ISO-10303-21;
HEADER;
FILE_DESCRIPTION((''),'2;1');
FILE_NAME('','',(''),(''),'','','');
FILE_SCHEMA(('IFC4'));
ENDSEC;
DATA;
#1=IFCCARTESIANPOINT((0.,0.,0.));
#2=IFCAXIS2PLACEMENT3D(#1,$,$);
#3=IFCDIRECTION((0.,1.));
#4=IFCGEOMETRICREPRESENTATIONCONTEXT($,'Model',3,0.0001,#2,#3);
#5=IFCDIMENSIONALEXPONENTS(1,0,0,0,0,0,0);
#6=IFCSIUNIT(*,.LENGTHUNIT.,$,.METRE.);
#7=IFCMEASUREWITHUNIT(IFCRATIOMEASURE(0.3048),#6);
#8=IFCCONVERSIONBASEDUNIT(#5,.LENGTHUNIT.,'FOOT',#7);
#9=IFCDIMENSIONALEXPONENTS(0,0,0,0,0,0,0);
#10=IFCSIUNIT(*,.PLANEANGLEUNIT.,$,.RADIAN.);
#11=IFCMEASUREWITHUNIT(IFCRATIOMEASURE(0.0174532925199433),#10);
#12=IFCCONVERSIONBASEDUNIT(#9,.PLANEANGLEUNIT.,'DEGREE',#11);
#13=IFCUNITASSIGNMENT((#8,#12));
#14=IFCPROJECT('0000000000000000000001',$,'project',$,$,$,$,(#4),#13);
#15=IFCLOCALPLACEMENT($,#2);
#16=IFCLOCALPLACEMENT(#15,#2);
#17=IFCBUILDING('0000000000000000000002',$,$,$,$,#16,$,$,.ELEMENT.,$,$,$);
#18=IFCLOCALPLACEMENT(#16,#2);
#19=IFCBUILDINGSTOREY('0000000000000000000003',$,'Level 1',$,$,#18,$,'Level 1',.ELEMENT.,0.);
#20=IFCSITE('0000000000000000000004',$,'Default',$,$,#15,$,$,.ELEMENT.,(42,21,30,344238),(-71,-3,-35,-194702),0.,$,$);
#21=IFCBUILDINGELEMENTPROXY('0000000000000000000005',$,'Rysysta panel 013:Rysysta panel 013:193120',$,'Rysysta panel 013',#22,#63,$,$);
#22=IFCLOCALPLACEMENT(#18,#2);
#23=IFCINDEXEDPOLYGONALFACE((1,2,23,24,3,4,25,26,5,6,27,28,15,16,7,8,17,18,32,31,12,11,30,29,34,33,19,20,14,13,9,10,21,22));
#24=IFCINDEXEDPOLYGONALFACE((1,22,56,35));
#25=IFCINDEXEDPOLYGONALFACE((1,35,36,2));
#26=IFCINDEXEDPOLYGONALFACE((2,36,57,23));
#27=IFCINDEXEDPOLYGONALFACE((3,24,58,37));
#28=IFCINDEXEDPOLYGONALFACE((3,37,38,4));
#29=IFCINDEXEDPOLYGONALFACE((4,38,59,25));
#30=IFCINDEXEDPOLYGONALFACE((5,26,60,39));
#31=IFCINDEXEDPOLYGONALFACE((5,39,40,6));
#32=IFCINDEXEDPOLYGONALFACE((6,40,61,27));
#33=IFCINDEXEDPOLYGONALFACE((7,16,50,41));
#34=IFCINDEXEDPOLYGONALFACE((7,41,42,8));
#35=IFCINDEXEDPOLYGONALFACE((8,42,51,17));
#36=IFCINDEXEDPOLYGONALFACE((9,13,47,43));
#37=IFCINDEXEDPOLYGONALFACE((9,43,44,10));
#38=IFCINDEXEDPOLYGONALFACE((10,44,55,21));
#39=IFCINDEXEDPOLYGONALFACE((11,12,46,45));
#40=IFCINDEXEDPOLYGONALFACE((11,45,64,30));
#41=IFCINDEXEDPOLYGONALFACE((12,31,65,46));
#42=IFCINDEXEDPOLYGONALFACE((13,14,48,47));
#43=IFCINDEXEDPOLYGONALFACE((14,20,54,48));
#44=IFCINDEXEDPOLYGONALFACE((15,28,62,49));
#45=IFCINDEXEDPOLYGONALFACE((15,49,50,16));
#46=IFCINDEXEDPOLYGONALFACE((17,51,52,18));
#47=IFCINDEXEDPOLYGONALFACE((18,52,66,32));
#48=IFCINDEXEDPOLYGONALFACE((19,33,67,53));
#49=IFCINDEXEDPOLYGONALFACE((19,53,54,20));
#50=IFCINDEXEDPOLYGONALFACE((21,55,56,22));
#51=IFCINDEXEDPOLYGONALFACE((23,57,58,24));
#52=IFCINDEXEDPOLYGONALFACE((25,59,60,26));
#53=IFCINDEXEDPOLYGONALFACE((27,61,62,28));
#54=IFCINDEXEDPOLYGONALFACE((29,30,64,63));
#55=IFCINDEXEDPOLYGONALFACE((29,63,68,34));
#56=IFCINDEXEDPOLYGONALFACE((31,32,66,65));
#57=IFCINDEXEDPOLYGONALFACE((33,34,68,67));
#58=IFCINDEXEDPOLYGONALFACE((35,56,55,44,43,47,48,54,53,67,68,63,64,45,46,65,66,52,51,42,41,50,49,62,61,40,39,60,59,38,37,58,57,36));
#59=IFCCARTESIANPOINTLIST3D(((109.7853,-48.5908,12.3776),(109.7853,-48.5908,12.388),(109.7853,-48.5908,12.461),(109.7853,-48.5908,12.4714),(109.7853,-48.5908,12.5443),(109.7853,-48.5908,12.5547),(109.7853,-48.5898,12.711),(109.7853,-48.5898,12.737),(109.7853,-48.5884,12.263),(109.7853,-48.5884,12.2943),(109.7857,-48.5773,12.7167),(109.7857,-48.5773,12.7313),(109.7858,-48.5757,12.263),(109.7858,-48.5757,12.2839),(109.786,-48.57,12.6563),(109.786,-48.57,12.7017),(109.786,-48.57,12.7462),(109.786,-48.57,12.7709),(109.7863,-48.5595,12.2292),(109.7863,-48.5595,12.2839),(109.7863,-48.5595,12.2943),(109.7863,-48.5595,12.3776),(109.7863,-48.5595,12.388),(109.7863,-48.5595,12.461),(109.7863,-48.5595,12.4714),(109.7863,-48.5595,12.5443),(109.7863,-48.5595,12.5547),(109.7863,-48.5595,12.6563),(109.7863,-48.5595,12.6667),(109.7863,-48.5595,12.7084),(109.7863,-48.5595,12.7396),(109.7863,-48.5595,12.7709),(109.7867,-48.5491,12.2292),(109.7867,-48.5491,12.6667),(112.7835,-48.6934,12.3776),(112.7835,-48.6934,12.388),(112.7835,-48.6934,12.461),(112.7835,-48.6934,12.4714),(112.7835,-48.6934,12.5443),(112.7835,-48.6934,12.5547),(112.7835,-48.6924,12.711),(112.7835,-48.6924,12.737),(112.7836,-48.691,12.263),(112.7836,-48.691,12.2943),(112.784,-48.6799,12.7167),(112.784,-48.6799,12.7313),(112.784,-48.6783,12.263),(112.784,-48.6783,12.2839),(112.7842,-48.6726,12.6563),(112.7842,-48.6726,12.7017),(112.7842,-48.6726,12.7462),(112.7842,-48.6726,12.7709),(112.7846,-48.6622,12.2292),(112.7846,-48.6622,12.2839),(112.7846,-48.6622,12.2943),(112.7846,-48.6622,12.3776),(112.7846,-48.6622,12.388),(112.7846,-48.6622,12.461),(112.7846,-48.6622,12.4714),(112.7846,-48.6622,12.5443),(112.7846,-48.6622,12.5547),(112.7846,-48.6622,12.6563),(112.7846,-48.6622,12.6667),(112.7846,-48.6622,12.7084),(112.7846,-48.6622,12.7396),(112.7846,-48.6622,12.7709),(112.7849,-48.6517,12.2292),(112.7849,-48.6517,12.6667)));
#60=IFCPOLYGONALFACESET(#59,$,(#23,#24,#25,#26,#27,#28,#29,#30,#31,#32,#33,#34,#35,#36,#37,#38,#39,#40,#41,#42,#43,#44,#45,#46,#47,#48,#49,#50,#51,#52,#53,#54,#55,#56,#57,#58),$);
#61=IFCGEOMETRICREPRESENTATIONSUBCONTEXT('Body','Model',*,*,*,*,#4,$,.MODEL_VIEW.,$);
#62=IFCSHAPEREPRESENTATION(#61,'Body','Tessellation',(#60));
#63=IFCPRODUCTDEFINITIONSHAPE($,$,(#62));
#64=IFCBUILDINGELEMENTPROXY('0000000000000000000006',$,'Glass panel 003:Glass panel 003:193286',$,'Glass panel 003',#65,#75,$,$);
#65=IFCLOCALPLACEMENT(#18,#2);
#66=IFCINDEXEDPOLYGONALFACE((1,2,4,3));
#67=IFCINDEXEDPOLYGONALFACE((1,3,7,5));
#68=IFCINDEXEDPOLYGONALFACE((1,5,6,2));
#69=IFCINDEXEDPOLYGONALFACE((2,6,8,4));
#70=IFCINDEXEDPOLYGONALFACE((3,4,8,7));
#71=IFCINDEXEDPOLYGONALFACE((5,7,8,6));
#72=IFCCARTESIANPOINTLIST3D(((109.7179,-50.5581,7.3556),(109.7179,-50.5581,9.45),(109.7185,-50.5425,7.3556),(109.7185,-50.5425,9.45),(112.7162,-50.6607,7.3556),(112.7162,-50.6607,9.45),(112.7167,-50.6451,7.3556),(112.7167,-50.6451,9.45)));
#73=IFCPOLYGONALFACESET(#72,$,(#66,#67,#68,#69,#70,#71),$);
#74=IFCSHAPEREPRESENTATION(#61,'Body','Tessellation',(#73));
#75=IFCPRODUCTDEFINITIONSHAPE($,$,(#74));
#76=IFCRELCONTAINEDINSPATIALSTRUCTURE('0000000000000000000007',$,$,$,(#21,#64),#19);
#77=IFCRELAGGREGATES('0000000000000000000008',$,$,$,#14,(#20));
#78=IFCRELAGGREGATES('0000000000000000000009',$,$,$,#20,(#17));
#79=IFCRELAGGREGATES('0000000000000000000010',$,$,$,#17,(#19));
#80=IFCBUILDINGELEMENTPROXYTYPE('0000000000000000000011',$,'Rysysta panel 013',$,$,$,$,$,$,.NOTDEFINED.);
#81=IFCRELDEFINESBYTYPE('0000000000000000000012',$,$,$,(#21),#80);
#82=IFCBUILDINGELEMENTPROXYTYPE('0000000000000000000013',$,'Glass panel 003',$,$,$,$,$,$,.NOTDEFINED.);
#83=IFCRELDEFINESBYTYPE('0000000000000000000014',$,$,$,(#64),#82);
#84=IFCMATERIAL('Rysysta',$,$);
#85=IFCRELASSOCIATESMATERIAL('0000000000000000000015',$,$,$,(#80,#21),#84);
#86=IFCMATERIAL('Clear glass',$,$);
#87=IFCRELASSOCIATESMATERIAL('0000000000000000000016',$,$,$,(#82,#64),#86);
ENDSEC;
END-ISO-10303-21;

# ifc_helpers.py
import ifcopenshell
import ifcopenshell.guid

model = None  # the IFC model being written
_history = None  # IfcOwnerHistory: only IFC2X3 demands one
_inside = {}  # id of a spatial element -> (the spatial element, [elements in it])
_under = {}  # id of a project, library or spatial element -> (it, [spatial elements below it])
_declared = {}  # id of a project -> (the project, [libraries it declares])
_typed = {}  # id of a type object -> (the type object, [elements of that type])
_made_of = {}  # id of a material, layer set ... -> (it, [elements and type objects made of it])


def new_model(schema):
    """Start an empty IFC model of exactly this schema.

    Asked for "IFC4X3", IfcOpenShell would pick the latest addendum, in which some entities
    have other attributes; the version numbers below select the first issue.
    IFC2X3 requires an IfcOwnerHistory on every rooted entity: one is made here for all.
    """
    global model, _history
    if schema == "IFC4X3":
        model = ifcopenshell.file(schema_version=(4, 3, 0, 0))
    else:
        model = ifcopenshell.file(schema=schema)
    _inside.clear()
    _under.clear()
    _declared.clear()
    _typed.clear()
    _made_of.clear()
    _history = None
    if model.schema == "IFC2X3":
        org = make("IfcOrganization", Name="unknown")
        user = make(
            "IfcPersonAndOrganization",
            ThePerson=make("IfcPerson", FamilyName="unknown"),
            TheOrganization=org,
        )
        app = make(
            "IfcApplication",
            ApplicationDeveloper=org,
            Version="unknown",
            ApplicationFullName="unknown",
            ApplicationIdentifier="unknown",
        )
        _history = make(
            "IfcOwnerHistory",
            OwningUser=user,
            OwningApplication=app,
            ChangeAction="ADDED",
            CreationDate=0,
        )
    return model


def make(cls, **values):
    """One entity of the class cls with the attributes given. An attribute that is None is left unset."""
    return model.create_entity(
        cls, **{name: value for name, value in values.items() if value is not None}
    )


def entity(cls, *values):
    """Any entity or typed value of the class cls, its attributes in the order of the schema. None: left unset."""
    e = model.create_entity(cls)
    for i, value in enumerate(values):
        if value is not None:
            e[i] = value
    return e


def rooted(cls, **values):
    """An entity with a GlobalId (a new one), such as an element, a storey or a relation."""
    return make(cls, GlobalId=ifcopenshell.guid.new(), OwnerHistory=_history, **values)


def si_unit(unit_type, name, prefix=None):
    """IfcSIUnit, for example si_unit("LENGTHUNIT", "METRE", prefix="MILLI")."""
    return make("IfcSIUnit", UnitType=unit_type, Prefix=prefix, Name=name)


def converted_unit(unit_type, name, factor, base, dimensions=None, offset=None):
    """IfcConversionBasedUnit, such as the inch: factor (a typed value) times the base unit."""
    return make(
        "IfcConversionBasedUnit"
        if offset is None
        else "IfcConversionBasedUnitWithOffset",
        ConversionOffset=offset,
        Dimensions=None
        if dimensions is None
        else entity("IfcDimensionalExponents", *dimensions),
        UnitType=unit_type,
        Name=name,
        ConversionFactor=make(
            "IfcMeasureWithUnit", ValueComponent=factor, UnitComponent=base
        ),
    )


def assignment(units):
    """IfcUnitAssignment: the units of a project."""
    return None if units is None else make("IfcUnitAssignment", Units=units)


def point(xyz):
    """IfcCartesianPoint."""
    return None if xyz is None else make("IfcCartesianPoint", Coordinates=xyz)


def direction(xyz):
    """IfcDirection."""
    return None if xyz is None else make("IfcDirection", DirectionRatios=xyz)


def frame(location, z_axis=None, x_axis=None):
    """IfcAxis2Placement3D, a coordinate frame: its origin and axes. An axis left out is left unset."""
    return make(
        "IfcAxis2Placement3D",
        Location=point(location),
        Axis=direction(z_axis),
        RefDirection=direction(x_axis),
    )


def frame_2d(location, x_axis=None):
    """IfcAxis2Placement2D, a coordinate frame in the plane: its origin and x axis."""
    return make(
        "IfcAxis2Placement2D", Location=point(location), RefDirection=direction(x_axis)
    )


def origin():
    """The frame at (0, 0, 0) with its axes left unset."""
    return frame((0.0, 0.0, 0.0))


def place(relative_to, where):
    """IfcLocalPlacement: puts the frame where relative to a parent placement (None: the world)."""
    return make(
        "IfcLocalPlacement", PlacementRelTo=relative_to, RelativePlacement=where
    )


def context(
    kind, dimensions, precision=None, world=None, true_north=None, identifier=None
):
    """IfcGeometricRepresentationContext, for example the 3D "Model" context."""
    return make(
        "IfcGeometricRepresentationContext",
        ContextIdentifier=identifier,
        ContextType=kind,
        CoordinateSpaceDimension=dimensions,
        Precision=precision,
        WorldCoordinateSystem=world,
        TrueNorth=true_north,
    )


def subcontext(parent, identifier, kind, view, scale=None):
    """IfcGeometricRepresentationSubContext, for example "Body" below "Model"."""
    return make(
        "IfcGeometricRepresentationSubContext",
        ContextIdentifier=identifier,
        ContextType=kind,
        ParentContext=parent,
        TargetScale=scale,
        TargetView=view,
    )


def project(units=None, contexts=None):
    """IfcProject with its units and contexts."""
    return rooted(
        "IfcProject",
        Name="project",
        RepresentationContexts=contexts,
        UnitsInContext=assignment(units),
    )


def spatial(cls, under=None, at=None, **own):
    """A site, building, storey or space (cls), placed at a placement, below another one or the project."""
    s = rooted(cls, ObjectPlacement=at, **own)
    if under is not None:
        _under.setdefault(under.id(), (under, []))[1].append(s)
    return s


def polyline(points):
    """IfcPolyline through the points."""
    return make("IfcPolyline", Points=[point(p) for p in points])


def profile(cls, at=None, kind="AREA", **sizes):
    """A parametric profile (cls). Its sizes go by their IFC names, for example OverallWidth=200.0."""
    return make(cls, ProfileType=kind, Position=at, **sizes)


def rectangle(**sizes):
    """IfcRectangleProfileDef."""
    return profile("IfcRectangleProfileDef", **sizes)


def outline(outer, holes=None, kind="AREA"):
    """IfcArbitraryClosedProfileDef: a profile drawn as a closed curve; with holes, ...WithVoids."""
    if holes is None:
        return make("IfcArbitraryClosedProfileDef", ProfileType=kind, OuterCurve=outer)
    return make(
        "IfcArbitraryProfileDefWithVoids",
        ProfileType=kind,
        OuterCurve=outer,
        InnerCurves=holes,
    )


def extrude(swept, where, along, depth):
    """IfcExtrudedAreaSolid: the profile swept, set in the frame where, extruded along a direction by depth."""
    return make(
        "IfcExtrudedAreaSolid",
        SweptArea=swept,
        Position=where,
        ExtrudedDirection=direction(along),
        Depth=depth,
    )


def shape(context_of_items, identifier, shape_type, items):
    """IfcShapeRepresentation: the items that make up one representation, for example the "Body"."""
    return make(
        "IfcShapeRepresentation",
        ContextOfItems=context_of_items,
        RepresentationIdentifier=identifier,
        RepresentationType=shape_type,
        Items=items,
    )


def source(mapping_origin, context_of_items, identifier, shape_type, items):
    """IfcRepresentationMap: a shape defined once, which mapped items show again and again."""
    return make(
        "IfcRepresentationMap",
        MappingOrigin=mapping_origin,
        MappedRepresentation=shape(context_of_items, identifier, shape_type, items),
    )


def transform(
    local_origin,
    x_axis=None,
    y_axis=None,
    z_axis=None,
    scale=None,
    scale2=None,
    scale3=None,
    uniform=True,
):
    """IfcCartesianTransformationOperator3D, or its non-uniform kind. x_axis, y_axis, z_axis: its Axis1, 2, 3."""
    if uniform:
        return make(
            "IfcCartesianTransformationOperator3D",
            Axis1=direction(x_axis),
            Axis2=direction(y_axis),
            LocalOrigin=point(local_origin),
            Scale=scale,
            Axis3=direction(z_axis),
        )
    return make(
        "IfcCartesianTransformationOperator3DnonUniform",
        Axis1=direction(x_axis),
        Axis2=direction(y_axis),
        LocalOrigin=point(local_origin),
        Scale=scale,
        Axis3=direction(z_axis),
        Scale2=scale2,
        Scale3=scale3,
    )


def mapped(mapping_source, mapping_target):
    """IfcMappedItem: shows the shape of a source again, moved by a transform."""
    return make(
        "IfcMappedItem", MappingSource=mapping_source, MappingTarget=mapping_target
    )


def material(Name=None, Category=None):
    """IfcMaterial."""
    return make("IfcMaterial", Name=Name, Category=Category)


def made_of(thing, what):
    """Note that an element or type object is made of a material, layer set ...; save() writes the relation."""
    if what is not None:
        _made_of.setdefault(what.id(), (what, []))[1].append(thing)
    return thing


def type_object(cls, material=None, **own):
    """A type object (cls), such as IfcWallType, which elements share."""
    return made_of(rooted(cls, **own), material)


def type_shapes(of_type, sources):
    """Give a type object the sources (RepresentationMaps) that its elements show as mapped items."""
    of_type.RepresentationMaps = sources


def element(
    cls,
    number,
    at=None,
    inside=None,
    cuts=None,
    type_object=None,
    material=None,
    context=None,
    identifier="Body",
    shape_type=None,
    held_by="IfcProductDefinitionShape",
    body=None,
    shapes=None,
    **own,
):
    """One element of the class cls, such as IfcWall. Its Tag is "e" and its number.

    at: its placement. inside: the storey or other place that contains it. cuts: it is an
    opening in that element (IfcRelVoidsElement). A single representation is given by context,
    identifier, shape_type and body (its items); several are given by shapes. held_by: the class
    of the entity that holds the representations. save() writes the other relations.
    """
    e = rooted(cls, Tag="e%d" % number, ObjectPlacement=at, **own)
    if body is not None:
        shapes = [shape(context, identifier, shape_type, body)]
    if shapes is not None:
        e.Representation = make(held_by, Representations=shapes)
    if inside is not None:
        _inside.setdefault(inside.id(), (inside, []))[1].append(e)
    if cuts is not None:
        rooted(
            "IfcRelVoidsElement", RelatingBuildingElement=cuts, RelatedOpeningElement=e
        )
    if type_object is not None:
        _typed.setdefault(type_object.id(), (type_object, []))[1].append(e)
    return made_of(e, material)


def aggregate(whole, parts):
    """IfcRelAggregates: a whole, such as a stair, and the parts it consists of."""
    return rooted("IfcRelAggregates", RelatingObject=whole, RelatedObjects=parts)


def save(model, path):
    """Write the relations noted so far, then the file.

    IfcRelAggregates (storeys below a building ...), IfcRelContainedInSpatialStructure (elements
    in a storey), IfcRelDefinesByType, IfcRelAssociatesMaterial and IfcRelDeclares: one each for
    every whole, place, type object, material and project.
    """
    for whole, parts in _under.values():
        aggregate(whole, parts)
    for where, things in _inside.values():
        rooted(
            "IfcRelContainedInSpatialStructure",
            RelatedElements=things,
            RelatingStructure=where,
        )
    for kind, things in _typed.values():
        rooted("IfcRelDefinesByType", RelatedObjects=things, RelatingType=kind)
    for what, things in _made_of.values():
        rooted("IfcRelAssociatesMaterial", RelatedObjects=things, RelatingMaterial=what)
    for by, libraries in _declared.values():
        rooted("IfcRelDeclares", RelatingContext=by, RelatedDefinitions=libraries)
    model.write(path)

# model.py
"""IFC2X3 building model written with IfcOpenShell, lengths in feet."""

from ifc_helpers import new_model, entity, si_unit, converted_unit, direction, frame, frame_2d, origin, place, context, subcontext, project, spatial, polyline, rectangle, outline, extrude, source, transform, mapped, material, type_object, type_shapes, element, save


model = new_model("IFC2X3")

# Units and contexts
model_context = context("Model", 3, precision=0.0001, world=origin(), true_north=direction((0.0, 1.0)))
body_context = subcontext(model_context, "Body", "Model", "MODEL_VIEW")
ifc_project = project(units=[converted_unit("LENGTHUNIT", "FOOT", entity("IfcRatioMeasure", 0.3048), si_unit("LENGTHUNIT", "METRE"), dimensions=[1, 0, 0, 0, 0, 0, 0]), converted_unit("PLANEANGLEUNIT", "DEGREE", entity("IfcRatioMeasure", 0.0174532925199433), si_unit("PLANEANGLEUNIT", "RADIAN"), dimensions=[0, 0, 0, 0, 0, 0, 0])], contexts=[model_context])

# Site, building, storey
site_placement = place(None, origin())
site = spatial("IfcSite", under=ifc_project, at=site_placement, Name="Default", CompositionType="ELEMENT", RefLatitude=(42, 21, 30, 344238), RefLongitude=(-71, -3, -35, -194702), RefElevation=0.0)
building_placement = place(site_placement, origin())
building = spatial("IfcBuilding", under=site, at=building_placement, CompositionType="ELEMENT")
storey_placement = place(building_placement, origin())
storey = spatial("IfcBuildingStorey", under=building, at=storey_placement, Name="Level 1", LongName="Level 1", CompositionType="ELEMENT", Elevation=0.0)

# Building element proxies
ifc_material_1 = material(Name="Rysysta")
ifc_material_2 = material(Name="Clear glass")
building_element_proxy_type_1 = type_object("IfcBuildingElementProxyType", Name="Rysysta panel 013", PredefinedType="NOTDEFINED", material=ifc_material_1)
shared_shape_1 = source(origin(), body_context, "Body", "SweptSolid", [
    extrude(outline(polyline([(-0.022, 0.1457), (-0.022, -0.2918), (-0.0116, -0.2918), (-0.0116, -0.2371), (0.0045, -0.2371), (0.0045, -0.258), (0.0173, -0.258), (0.0173, -0.2267), (-0.0116, -0.2267), (-0.0116, -0.1434), (0.0196, -0.1434), (0.0196, -0.133), (-0.0116, -0.133), (-0.0116, -0.06), (0.0196, -0.06), (0.0196, -0.0496), (-0.0116, -0.0496), (-0.0116, 0.0233), (0.0196, 0.0233), (0.0196, 0.0337), (-0.0116, 0.0337), (-0.0116, 0.1353), (-0.0012, 0.1353), (-0.0012, 0.1807), (0.0186, 0.1899), (0.0186, 0.216), (-0.0012, 0.2252), (-0.0012, 0.2498), (-0.0116, 0.2498), (-0.0116, 0.2186), (0.0062, 0.2103), (0.0062, 0.1956), (-0.0116, 0.1873), (-0.0116, 0.1457), (-0.022, 0.1457)])), frame((109.7859, -48.5711, 12.521), z_axis=(-0.999415, 0.034202, 0.0), x_axis=(-0.034202, -0.999415, 0.0)), (0.0, 0.0, -1.0), 3.0),
])
type_shapes(building_element_proxy_type_1, [shared_shape_1])
proxy_1_placement = place(storey_placement, origin())
element("IfcBuildingElementProxy", 1, at=proxy_1_placement, inside=storey, type_object=building_element_proxy_type_1, material=ifc_material_1, Name="Rysysta panel 013:Rysysta panel 013:193120", ObjectType="Rysysta panel 013", context=body_context, shape_type="MappedRepresentation", body=[
    mapped(shared_shape_1, transform((0.0, 0.0, 0.0), scale=1.0)),
])
building_element_proxy_type_2 = type_object("IfcBuildingElementProxyType", Name="Glass panel 003", PredefinedType="NOTDEFINED", material=ifc_material_2)
shared_shape_2 = source(origin(), body_context, "Body", "SweptSolid", [
    extrude(rectangle(XDim=3.0, YDim=0.0156, at=frame_2d((0.0, 0.0), x_axis=(1.0, 0.0))), frame((111.2173, -50.6016, 7.3556), z_axis=(0.0, 0.0, 1.0), x_axis=(-0.999415, 0.034202, 0.0)), (0.0, 0.0, 1.0), 2.0943),
])
type_shapes(building_element_proxy_type_2, [shared_shape_2])
proxy_2_placement = place(storey_placement, origin())
element("IfcBuildingElementProxy", 2, at=proxy_2_placement, inside=storey, type_object=building_element_proxy_type_2, material=ifc_material_2, Name="Glass panel 003:Glass panel 003:193286", ObjectType="Glass panel 003", context=body_context, shape_type="MappedRepresentation", body=[
    mapped(shared_shape_2, transform((0.0, 0.0, 0.0), scale=1.0)),
])

save(model, "model.ifc")
